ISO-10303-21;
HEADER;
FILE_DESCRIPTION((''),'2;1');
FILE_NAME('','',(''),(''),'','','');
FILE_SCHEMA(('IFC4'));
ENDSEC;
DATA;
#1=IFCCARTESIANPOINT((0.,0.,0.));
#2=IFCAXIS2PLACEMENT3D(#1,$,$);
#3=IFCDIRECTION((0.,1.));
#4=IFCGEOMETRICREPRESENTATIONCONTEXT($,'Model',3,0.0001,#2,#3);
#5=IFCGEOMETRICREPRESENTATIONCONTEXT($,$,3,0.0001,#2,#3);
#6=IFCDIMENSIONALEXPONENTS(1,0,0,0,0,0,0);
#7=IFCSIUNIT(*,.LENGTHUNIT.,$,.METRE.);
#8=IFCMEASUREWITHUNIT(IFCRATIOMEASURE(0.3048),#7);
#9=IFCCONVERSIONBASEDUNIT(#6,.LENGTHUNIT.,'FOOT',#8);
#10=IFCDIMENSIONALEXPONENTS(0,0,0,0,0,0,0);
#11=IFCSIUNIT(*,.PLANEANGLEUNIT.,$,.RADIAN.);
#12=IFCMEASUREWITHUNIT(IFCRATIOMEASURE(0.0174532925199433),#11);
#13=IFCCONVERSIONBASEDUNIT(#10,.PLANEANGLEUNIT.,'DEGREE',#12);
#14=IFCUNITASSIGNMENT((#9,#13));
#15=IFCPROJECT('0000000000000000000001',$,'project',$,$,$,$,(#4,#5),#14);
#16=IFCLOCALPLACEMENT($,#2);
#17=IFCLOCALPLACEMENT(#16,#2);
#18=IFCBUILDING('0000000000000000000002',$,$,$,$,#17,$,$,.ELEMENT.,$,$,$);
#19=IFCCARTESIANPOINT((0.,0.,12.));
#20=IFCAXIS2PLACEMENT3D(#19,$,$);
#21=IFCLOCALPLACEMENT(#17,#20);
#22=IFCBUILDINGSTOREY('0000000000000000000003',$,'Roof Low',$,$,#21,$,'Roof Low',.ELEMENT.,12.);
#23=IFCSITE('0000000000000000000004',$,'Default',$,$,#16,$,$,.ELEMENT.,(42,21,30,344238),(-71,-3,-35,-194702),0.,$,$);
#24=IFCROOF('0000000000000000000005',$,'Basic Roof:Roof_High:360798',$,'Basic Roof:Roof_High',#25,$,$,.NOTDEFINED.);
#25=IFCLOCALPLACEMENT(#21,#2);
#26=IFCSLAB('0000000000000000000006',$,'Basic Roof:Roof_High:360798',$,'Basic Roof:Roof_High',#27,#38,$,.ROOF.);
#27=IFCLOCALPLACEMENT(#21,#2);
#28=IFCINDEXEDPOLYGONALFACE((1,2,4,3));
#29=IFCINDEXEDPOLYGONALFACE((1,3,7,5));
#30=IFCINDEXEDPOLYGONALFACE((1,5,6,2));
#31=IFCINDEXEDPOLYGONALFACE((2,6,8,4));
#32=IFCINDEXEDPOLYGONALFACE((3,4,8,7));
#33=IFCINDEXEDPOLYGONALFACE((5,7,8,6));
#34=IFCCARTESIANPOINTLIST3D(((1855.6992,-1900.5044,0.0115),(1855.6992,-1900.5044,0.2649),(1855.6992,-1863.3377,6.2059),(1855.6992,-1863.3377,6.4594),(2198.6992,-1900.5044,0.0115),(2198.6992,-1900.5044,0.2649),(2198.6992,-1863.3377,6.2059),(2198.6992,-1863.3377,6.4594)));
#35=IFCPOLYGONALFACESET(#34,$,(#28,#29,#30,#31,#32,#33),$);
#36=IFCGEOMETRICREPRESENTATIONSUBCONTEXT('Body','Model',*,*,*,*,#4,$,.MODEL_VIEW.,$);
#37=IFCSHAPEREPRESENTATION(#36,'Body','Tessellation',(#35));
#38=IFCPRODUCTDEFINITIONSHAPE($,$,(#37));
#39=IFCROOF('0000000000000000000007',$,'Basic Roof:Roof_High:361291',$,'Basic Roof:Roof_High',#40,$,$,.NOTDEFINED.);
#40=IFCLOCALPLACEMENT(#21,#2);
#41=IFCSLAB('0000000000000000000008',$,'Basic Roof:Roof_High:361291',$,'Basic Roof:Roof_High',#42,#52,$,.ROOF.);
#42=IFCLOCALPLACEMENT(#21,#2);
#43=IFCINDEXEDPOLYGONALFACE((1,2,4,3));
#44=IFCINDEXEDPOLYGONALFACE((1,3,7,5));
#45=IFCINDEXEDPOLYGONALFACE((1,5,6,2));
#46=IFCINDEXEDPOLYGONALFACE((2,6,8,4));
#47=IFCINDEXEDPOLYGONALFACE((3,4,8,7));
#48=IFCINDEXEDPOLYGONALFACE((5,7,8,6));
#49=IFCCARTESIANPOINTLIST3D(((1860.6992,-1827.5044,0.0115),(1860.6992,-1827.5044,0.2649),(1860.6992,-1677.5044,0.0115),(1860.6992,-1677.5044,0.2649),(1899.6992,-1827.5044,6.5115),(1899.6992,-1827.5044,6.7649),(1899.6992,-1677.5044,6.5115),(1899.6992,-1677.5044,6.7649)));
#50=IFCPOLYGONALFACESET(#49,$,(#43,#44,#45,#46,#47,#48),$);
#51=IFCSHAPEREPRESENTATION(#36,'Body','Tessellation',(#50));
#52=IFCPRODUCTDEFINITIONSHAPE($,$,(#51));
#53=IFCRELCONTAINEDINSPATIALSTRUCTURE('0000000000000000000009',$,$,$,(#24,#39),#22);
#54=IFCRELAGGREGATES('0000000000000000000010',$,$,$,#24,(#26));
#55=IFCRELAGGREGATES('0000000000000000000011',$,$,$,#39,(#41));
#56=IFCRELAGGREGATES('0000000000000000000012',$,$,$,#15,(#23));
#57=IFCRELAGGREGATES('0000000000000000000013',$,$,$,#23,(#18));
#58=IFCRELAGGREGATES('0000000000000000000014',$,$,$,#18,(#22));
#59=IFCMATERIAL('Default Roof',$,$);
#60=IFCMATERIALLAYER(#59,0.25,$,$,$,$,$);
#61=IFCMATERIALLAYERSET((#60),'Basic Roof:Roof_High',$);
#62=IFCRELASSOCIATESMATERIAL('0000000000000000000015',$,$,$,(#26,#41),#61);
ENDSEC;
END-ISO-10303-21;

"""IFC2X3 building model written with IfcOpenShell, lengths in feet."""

from ifc_helpers import new_model, entity, si_unit, converted_unit, direction, frame, frame_2d, origin, place, context, subcontext, project, spatial, rectangle, extrude, material, layer, layer_set, element, aggregate, save


model = new_model("IFC2X3")

# Units and contexts
model_context = context("Model", 3, precision=0.0001, world=origin(), true_north=direction((0.0, 1.0)))
context_of_model = context(None, 3, precision=0.0001, world=origin(), true_north=direction((0.0, 1.0)))
body_context = subcontext(model_context, "Body", "Model", "MODEL_VIEW")
ifc_project = project(units=[converted_unit("LENGTHUNIT", "FOOT", entity("IfcRatioMeasure", 0.3048), si_unit("LENGTHUNIT", "METRE"), dimensions=[1, 0, 0, 0, 0, 0, 0]), converted_unit("PLANEANGLEUNIT", "DEGREE", entity("IfcRatioMeasure", 0.0174532925199433), si_unit("PLANEANGLEUNIT", "RADIAN"), dimensions=[0, 0, 0, 0, 0, 0, 0])], contexts=[model_context, context_of_model])

# Site, building, storey
site_placement = place(None, origin())
site = spatial("IfcSite", under=ifc_project, at=site_placement, Name="Default", CompositionType="ELEMENT", RefLatitude=(42, 21, 30, 344238), RefLongitude=(-71, -3, -35, -194702), RefElevation=0.0)
building_placement = place(site_placement, origin())
building = spatial("IfcBuilding", under=site, at=building_placement, CompositionType="ELEMENT")
storey_placement = place(building_placement, frame((0.0, 0.0, 12.0)))
storey = spatial("IfcBuildingStorey", under=building, at=storey_placement, Name="Roof Low", LongName="Roof Low", CompositionType="ELEMENT", Elevation=12.0)

# Roofs, slabs
roof_1_placement = place(storey_placement, frame((1855.6992, -1900.5044, 0.0115)))
roof_1 = element("IfcRoof", 1, at=roof_1_placement, inside=storey, Name="Basic Roof:Roof_High:360798", ObjectType="Basic Roof:Roof_High", ShapeType="NOTDEFINED")
ifc_material = material(Name="Default Roof")
ifc_layer = layer(ifc_material, 0.25)
ifc_layer_set = layer_set([ifc_layer], Name="Basic Roof:Roof_High")
slab_1_placement = place(roof_1_placement, origin())
slab_1 = element("IfcSlab", 2, at=slab_1_placement, material=ifc_layer_set, Name="Basic Roof:Roof_High:360798", ObjectType="Basic Roof:Roof_High", PredefinedType="ROOF", context=body_context, shape_type="SweptSolid", body=[
    extrude(rectangle(XDim=37.6793, YDim=343.0, at=frame_2d((0.0, 0.0), x_axis=(0.0, -1.0))), frame((171.5, 18.5833, 3.0972), z_axis=(0.0, -0.164399, 0.986394), x_axis=(1.0, 0.0, 0.0)), (0.0, 0.164399, 0.986394), 0.2534),
])
aggregate(roof_1, [slab_1])
roof_2_placement = place(storey_placement, frame((1860.6992, -1827.5044, 0.0115)))
roof_2 = element("IfcRoof", 3, at=roof_2_placement, inside=storey, Name="Basic Roof:Roof_High:361291", ObjectType="Basic Roof:Roof_High", ShapeType="NOTDEFINED")
slab_2_placement = place(roof_2_placement, origin())
slab_2 = element("IfcSlab", 4, at=slab_2_placement, material=ifc_layer_set, Name="Basic Roof:Roof_High:361291", ObjectType="Basic Roof:Roof_High", PredefinedType="ROOF", context=body_context, shape_type="SweptSolid", body=[
    extrude(rectangle(XDim=39.538, YDim=150.0, at=frame_2d((0.0, 0.0), x_axis=(-1.0, 0.0))), frame((19.5, 75.0, 3.25), z_axis=(-0.164399, 0.0, 0.986394), x_axis=(0.986394, 0.0, 0.164399)), (0.164399, 0.0, 0.986394), 0.2534),
])
aggregate(roof_2, [slab_2])

save(model, "model.ifc")
